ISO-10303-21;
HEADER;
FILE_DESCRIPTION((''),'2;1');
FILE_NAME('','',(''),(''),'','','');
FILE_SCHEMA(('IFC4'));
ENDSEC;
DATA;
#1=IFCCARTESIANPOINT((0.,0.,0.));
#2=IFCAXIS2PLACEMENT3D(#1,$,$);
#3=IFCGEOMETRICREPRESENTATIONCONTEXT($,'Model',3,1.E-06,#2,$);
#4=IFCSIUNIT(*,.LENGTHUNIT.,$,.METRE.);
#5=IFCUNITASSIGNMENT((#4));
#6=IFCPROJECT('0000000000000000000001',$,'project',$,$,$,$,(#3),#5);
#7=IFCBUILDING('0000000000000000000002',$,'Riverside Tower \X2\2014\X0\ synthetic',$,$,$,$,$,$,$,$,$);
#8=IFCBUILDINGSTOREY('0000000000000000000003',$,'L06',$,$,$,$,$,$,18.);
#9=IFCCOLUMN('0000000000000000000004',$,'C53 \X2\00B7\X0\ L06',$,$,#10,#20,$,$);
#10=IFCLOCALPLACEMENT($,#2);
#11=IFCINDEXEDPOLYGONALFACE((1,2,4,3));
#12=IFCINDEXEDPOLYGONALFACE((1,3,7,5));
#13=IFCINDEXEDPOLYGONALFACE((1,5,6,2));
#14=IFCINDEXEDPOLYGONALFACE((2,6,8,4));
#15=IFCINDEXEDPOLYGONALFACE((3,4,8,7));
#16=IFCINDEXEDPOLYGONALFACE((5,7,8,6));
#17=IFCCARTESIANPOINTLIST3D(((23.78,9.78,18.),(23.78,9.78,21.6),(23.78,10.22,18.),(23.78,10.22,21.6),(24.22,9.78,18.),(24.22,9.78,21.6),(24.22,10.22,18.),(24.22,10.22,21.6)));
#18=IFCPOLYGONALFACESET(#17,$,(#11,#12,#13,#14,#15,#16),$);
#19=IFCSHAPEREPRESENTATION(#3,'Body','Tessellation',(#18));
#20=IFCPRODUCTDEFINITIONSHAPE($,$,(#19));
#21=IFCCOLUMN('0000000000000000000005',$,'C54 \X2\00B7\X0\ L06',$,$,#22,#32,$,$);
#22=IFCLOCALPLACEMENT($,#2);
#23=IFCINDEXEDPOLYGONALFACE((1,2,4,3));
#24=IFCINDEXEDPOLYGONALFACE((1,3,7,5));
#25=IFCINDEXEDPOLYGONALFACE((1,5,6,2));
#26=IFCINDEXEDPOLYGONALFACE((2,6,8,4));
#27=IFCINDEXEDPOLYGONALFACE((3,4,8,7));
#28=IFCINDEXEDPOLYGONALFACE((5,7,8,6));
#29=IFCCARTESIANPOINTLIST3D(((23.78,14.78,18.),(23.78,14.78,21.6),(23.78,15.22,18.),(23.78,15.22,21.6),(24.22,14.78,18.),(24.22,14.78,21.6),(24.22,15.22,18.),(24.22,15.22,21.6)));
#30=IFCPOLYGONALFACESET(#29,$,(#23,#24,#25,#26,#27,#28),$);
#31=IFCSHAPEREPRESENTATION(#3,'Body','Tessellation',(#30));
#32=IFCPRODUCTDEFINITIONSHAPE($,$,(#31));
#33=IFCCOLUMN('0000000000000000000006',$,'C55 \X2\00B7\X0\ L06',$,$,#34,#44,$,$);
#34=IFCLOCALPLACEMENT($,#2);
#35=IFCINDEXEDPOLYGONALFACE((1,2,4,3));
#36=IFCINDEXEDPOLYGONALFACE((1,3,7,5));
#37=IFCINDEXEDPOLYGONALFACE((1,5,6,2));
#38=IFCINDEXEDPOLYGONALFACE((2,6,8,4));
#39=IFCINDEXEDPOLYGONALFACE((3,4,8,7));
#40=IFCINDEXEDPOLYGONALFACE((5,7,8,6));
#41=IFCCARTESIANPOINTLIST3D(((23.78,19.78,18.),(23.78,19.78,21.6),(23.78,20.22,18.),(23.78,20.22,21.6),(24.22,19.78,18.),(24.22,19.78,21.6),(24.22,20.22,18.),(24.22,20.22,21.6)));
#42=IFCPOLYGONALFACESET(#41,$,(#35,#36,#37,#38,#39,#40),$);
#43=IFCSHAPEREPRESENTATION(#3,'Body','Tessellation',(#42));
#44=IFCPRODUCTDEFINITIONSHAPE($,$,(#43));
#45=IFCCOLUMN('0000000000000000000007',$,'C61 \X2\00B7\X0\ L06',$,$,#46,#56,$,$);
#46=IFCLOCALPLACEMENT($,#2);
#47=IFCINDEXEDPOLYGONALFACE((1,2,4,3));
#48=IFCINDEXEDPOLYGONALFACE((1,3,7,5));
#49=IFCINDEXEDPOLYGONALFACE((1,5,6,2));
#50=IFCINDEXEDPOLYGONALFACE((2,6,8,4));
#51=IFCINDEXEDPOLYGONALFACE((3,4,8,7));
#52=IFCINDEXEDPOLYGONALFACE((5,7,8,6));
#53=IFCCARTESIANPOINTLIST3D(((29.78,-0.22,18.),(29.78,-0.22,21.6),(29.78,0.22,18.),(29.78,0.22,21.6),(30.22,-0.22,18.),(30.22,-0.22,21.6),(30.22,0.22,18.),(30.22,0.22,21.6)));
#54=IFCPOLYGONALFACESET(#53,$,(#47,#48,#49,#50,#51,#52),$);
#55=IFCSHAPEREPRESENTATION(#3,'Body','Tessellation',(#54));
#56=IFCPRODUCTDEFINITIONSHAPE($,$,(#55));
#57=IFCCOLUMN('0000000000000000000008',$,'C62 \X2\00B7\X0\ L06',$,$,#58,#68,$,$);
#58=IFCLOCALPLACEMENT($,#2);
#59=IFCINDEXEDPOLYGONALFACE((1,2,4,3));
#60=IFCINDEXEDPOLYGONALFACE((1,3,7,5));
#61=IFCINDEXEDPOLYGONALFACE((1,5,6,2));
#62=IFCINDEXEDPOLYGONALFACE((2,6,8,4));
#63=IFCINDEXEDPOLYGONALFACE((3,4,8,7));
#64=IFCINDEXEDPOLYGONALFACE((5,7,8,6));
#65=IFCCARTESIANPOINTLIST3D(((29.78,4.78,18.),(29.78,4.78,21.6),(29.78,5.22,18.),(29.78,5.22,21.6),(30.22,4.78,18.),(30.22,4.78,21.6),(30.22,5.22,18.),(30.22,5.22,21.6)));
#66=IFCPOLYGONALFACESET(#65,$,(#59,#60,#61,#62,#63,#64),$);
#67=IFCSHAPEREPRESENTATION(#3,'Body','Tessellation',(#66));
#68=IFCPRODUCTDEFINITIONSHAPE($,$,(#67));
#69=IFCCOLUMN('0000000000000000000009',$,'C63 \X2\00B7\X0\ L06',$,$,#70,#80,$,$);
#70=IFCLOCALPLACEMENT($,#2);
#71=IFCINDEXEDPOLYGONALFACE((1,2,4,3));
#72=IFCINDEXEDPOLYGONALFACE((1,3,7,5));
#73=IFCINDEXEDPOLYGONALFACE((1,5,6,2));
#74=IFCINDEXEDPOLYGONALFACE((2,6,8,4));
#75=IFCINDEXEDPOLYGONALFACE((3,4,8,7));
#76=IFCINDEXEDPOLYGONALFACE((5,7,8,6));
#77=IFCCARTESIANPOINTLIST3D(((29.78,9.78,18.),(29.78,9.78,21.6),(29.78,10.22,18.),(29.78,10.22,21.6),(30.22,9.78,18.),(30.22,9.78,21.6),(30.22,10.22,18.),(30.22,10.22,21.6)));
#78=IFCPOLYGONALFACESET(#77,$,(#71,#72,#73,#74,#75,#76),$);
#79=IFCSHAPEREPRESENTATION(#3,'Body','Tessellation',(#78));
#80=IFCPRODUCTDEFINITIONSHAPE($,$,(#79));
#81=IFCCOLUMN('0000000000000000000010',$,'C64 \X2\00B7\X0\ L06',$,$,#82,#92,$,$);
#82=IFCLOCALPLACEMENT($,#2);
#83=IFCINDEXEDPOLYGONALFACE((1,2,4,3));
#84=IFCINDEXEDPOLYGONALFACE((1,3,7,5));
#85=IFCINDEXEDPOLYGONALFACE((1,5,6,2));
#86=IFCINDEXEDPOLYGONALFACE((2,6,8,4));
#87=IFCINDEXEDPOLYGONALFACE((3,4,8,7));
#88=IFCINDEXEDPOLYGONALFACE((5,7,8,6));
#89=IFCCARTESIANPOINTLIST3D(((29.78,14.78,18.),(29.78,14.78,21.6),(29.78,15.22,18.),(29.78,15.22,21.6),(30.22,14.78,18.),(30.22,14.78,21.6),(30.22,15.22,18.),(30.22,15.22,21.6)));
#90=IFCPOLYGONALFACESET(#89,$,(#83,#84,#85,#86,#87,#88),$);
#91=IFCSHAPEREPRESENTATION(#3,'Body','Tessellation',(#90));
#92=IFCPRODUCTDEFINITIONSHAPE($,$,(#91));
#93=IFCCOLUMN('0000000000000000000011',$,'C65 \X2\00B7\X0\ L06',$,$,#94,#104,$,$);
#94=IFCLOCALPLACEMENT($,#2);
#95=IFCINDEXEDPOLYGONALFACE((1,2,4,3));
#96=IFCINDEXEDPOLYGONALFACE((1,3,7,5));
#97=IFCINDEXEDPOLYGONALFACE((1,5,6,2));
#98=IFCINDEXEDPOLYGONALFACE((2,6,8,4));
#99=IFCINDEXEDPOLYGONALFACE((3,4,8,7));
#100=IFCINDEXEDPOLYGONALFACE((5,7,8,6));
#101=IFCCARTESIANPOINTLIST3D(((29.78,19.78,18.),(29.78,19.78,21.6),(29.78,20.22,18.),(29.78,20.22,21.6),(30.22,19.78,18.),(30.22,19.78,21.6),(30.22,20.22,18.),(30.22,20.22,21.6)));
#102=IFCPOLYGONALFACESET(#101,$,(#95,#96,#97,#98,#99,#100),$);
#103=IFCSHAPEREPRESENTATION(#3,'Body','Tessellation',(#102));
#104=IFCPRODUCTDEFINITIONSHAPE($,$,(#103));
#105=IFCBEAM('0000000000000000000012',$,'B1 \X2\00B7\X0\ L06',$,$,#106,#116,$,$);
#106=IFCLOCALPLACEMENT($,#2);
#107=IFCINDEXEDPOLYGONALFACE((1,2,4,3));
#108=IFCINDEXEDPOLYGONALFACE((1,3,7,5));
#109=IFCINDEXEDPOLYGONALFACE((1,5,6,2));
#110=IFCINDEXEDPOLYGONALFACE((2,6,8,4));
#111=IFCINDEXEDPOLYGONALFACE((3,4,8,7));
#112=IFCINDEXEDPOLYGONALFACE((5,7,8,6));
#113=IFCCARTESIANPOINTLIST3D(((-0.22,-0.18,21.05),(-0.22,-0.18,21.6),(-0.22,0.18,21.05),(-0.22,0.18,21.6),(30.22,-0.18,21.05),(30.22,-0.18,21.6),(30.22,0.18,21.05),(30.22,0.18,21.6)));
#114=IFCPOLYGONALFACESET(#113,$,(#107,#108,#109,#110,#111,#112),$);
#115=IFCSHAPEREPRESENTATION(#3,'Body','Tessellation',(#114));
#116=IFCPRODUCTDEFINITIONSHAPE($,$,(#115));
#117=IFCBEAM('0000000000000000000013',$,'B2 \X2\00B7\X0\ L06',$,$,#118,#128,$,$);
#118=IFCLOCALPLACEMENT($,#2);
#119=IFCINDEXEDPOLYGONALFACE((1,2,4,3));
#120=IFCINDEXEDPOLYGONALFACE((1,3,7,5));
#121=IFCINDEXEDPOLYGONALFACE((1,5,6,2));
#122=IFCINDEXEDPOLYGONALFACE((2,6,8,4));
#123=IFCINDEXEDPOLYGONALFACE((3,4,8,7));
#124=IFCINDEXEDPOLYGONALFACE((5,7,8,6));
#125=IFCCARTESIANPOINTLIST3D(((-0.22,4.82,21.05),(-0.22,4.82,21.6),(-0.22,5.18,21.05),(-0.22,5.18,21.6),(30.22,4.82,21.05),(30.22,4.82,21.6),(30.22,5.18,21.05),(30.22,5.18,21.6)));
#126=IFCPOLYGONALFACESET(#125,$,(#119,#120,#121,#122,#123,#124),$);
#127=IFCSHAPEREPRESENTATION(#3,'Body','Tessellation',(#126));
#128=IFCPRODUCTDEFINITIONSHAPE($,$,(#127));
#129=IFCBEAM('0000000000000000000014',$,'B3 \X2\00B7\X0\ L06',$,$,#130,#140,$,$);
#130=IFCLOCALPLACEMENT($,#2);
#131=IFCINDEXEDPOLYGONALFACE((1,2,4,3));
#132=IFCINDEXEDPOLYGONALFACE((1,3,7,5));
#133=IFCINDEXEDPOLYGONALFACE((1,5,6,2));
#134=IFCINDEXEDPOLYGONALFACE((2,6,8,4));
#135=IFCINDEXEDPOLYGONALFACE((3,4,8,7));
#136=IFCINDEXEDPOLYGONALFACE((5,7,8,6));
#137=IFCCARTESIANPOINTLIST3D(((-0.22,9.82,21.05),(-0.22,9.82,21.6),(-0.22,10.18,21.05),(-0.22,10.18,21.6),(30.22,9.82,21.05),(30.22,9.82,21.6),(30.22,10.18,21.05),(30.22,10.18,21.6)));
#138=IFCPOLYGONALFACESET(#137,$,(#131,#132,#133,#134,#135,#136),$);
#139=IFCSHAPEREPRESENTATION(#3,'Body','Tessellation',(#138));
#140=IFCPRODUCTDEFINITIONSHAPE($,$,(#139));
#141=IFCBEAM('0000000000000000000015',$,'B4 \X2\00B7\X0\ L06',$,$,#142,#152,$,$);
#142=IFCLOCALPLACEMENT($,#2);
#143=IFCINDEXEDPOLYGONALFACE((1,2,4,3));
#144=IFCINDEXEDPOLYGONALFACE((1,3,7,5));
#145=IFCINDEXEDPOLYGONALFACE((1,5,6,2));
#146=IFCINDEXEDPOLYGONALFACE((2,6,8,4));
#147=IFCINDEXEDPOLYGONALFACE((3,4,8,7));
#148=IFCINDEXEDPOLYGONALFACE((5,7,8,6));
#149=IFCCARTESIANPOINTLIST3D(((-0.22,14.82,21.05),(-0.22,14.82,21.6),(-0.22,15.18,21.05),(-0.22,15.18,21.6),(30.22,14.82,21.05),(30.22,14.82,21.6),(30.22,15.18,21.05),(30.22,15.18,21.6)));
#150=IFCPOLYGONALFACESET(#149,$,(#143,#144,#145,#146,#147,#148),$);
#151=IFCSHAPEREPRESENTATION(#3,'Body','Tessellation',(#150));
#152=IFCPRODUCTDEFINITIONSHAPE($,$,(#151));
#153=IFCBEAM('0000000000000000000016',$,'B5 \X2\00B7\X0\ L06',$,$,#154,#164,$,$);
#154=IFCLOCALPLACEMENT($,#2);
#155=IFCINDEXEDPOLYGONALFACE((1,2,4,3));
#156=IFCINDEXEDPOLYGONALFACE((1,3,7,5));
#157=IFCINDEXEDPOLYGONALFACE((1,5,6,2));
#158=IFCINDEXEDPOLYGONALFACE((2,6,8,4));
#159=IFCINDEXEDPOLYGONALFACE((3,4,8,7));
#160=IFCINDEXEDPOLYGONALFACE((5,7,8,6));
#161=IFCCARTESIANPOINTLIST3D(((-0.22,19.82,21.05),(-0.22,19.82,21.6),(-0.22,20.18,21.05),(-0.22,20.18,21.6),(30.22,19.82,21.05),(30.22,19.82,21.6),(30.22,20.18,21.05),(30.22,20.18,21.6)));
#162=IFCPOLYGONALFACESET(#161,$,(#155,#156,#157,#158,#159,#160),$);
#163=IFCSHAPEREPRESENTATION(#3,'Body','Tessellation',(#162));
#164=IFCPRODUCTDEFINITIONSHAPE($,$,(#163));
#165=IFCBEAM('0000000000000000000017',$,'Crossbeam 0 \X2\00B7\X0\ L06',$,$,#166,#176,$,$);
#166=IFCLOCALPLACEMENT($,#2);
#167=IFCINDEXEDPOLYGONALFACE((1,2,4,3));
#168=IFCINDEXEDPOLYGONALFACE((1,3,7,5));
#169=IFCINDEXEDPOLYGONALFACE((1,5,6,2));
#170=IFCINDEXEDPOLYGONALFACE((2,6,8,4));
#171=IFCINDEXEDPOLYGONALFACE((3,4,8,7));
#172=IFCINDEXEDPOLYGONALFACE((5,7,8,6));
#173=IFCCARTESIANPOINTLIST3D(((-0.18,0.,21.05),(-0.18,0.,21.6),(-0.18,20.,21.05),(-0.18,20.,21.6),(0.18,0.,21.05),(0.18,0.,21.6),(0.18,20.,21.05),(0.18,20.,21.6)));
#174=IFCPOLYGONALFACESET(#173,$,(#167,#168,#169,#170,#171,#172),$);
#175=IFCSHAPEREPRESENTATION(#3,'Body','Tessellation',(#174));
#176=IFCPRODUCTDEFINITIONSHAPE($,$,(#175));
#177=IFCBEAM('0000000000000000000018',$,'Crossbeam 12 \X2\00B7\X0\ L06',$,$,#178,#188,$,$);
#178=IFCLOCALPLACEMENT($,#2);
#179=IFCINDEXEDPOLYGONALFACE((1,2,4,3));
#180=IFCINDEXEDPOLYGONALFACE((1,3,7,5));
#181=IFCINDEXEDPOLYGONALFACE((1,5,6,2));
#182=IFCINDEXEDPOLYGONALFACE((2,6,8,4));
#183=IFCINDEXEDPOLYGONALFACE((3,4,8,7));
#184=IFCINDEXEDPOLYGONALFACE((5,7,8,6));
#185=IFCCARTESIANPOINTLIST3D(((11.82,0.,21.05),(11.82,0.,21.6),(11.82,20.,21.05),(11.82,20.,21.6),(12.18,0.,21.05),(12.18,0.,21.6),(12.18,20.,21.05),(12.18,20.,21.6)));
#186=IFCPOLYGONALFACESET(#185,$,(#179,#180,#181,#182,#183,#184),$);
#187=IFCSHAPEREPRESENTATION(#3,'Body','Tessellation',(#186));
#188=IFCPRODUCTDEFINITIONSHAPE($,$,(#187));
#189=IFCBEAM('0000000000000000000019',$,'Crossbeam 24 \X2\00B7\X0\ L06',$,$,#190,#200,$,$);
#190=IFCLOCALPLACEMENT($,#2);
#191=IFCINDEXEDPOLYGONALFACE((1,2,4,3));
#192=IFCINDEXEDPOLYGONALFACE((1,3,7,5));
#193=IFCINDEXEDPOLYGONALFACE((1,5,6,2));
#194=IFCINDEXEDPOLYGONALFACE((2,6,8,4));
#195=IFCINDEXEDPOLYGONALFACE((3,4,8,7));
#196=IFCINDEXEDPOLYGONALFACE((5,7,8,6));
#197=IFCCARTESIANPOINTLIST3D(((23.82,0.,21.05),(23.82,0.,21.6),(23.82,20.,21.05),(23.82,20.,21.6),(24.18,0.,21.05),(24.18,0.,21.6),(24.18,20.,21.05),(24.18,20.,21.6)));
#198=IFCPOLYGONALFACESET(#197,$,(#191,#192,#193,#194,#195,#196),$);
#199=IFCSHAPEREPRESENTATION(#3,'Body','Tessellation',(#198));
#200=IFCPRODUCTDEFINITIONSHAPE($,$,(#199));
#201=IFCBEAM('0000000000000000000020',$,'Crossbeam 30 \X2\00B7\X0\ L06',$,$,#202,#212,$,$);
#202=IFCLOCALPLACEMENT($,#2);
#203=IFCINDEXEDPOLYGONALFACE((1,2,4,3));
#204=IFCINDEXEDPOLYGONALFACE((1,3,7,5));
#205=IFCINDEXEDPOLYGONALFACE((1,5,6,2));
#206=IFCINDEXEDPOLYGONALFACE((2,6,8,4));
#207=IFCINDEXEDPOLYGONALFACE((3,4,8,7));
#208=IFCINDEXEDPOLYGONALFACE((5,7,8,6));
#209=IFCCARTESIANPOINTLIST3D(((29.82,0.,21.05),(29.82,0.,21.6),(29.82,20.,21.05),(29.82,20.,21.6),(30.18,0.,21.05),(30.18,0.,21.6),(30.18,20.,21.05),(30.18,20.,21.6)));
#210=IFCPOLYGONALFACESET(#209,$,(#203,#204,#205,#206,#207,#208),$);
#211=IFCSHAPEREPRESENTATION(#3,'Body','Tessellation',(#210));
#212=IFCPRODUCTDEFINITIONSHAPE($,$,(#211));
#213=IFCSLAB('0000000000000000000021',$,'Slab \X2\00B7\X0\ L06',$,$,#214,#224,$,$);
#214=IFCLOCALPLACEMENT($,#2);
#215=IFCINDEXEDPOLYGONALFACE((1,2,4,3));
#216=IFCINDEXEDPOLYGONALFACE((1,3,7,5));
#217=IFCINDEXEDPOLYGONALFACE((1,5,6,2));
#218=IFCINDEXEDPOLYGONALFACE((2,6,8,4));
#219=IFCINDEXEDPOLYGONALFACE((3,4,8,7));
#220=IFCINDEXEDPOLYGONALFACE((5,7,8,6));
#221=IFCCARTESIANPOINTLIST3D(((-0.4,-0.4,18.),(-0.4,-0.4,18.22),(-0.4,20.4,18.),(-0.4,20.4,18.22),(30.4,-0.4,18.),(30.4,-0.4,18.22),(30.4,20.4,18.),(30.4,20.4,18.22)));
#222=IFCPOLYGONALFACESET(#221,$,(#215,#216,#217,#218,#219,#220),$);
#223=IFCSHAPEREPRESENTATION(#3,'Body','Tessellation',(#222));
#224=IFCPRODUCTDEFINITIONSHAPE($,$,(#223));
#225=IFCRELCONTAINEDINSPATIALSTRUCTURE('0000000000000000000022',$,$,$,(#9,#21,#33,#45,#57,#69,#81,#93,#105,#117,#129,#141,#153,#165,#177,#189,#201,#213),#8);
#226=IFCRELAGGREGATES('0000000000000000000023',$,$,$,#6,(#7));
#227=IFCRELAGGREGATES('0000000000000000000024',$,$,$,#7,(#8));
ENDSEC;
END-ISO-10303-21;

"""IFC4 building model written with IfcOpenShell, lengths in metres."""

from ifc_helpers import new_model, si_unit, frame, origin, place, context, project, spatial, rectangle, extrude, element, save


model = new_model("IFC4")

# Units and contexts
model_context = context("Model", 3, precision=1e-06, world=origin())
ifc_project = project(units=[si_unit("LENGTHUNIT", "METRE")], contexts=[model_context])

# Building, storey
building = spatial("IfcBuilding", under=ifc_project, Name="Riverside Tower — synthetic")
storey = spatial("IfcBuildingStorey", under=building, Name="L06", Elevation=18.0)

# Columns
for number, where, name in (
    (1, (24.0, 10.0, 18.0), "C53 · L06"),
    (2, (24.0, 15.0, 18.0), "C54 · L06"),
    (3, (24.0, 20.0, 18.0), "C55 · L06"),
    (4, (30.0, 0.0, 18.0), "C61 · L06"),
    (5, (30.0, 5.0, 18.0), "C62 · L06"),
    (6, (30.0, 10.0, 18.0), "C63 · L06"),
    (7, (30.0, 15.0, 18.0), "C64 · L06"),
    (8, (30.0, 20.0, 18.0), "C65 · L06"),
):
    element("IfcColumn", number, at=place(None, frame(where)), inside=storey, Name=name, context=model_context, shape_type="SweptSolid", body=[
        extrude(rectangle(XDim=0.44, YDim=0.44), origin(), (0.0, 0.0, 1.0), 3.6),
    ])

# Beams
for number, where, name in (
    (9, (15.0, 0.0, 21.05), "B1 · L06"),
    (10, (15.0, 5.0, 21.05), "B2 · L06"),
    (11, (15.0, 10.0, 21.05), "B3 · L06"),
    (12, (15.0, 15.0, 21.05), "B4 · L06"),
    (13, (15.0, 20.0, 21.05), "B5 · L06"),
):
    element("IfcBeam", number, at=place(None, frame(where)), inside=storey, Name=name, context=model_context, shape_type="SweptSolid", body=[
        extrude(rectangle(XDim=30.44, YDim=0.36), origin(), (0.0, 0.0, 1.0), 0.55),
    ])
for number, where, name in (
    (14, (0.0, 10.0, 21.05), "Crossbeam 0 · L06"),
    (15, (12.0, 10.0, 21.05), "Crossbeam 12 · L06"),
    (16, (24.0, 10.0, 21.05), "Crossbeam 24 · L06"),
    (17, (30.0, 10.0, 21.05), "Crossbeam 30 · L06"),
):
    element("IfcBeam", number, at=place(None, frame(where)), inside=storey, Name=name, context=model_context, shape_type="SweptSolid", body=[
        extrude(rectangle(XDim=0.36, YDim=20.0), origin(), (0.0, 0.0, 1.0), 0.55),
    ])

# Slab
slab_placement = place(None, frame((15.0, 10.0, 18.0)))
element("IfcSlab", 18, at=slab_placement, inside=storey, Name="Slab · L06", context=model_context, shape_type="SweptSolid", body=[
    extrude(rectangle(XDim=30.8, YDim=20.8), origin(), (0.0, 0.0, 1.0), 0.22),
])

save(model, "model.ifc")
